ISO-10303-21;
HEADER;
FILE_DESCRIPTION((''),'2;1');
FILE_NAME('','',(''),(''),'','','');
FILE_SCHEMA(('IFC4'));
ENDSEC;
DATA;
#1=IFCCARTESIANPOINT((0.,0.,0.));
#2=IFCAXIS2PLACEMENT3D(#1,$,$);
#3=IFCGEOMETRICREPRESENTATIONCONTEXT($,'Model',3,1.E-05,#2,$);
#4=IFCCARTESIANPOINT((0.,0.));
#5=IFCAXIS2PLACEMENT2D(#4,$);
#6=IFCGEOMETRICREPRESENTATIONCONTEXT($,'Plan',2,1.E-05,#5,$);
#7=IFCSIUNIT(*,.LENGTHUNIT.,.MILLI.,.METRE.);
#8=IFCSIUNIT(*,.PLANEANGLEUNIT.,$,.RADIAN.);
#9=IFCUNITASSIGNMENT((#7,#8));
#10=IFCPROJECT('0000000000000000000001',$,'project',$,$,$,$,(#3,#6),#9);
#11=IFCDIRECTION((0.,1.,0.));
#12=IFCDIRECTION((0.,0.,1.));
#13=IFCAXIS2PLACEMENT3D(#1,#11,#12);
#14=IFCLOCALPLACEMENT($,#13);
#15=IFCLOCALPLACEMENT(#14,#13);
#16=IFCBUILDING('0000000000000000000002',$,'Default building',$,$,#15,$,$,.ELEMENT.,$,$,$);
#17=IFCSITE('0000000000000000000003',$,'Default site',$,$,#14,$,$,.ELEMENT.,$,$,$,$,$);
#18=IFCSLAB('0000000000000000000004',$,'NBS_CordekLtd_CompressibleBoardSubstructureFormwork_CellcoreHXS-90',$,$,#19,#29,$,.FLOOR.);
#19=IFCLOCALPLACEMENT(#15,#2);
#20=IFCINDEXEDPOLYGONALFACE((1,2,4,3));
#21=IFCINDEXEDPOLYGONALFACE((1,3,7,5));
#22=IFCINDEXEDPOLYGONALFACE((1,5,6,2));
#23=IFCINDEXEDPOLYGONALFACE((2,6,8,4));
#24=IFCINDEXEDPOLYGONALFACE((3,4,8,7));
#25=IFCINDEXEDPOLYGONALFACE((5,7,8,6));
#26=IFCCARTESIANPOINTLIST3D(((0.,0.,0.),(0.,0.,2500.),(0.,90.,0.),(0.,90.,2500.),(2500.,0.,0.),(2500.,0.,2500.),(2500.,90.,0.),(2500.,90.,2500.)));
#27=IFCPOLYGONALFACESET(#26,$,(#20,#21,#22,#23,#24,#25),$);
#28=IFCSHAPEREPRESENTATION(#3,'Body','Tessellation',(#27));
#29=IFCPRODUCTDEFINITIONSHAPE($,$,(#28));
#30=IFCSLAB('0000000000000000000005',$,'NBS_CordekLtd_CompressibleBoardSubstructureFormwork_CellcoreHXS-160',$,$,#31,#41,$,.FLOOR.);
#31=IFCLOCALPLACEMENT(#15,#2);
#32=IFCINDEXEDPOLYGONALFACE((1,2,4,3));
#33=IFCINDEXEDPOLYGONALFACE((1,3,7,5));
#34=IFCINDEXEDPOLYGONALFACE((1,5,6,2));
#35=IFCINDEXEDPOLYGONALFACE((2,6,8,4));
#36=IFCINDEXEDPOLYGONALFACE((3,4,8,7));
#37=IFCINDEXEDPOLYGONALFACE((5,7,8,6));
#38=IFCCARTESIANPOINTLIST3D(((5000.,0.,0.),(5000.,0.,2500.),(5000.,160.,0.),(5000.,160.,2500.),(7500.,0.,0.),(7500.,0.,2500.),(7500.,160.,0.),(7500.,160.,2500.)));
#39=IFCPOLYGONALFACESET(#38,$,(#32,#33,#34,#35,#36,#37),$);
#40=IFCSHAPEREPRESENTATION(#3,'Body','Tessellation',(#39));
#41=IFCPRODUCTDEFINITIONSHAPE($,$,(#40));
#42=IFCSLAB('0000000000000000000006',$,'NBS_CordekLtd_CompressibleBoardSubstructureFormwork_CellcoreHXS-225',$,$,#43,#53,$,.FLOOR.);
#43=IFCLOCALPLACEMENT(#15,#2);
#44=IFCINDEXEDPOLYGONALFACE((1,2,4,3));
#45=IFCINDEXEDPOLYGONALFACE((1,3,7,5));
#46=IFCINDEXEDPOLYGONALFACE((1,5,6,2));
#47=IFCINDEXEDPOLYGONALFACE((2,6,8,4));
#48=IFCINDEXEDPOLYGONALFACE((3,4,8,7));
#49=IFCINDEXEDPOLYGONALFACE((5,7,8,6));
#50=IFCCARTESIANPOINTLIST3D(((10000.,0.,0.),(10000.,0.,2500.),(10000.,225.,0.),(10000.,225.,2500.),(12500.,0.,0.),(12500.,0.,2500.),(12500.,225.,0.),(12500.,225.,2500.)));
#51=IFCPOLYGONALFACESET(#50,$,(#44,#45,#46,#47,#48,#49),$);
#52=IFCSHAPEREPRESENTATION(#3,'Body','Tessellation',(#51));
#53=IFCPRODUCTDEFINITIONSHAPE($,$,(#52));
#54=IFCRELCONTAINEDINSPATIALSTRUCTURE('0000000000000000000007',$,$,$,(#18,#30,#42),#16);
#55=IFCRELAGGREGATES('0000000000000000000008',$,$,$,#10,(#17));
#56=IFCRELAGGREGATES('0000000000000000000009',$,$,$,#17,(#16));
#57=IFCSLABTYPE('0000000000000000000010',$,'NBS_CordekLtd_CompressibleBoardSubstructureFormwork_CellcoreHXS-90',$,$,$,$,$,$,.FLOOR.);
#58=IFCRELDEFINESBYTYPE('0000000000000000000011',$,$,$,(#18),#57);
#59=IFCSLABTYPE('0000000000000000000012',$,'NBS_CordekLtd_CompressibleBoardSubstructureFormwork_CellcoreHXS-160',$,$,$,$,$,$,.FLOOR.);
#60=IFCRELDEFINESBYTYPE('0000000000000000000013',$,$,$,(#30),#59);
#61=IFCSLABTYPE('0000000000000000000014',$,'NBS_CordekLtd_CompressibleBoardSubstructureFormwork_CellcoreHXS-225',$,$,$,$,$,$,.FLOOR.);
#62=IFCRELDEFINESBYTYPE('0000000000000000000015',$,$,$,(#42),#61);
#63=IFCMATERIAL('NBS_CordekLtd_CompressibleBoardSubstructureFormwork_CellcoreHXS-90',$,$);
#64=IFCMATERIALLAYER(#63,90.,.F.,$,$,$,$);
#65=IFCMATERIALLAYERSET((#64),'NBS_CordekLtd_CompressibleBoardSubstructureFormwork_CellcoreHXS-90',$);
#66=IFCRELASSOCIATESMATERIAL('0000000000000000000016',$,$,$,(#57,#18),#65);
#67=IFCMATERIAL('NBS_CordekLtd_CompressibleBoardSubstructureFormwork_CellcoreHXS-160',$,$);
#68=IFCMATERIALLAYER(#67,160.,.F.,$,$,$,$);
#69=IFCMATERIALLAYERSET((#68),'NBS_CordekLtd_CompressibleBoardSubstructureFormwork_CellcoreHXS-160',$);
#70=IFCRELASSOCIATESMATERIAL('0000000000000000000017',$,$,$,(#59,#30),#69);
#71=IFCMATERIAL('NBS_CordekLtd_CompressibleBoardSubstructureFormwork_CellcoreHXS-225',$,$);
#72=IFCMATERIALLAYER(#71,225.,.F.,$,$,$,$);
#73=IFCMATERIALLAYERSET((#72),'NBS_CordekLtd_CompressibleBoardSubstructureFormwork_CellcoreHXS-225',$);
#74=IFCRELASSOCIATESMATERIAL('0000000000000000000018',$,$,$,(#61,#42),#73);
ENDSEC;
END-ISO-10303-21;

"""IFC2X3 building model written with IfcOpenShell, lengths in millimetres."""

from ifc_helpers import new_model, si_unit, frame, frame_2d, origin, origin_with_axes, origin_2d, place, context, project, spatial, rectangle, extrude, material, layer, layer_set, layer_usage, type_object, element, save


model = new_model("IFC2X3")

# Units and contexts
model_context = context("Model", 3, precision=1e-05, world=origin())
plan_context = context("Plan", 2, precision=1e-05, world=origin_2d())
ifc_project = project(units=[si_unit("LENGTHUNIT", "METRE", prefix="MILLI"), si_unit("PLANEANGLEUNIT", "RADIAN")], contexts=[model_context, plan_context])

# Site, building
site_placement = place(None, frame((0.0, 0.0, 0.0), z_axis=(0.0, 1.0, 0.0), x_axis=(0.0, 0.0, 1.0)))
site = spatial("IfcSite", under=ifc_project, at=site_placement, Name="Default site", CompositionType="ELEMENT")
building_placement = place(site_placement, frame((0.0, 0.0, 0.0), z_axis=(0.0, 1.0, 0.0), x_axis=(0.0, 0.0, 1.0)))
building = spatial("IfcBuilding", under=site, at=building_placement, Name="Default building", CompositionType="ELEMENT")

# Slabs
ifc_material_1 = material(Name="NBS_CordekLtd_CompressibleBoardSubstructureFormwork_CellcoreHXS-90")
ifc_layer_1 = layer(ifc_material_1, 90.0, ventilated=False)
ifc_layer_set_1 = layer_set([ifc_layer_1], Name="NBS_CordekLtd_CompressibleBoardSubstructureFormwork_CellcoreHXS-90")
ifc_layer_usage_1 = layer_usage(ifc_layer_set_1, "AXIS3", "NEGATIVE", 0.0)
slab_type_1 = type_object("IfcSlabType", Name="NBS_CordekLtd_CompressibleBoardSubstructureFormwork_CellcoreHXS-90", PredefinedType="FLOOR", material=ifc_layer_set_1)
slab_1_placement = place(None, origin())
element("IfcSlab", 1, at=slab_1_placement, inside=building, type_object=slab_type_1, material=ifc_layer_usage_1, Name="NBS_CordekLtd_CompressibleBoardSubstructureFormwork_CellcoreHXS-90", PredefinedType="FLOOR", context=model_context, shape_type="SweptSolid", body=[
    extrude(rectangle(XDim=2500.0, YDim=2500.0, at=frame_2d((1250.0, 1250.0))), origin_with_axes(), (0.0, 0.0, 1.0), 90.0),
])
ifc_material_2 = material(Name="NBS_CordekLtd_CompressibleBoardSubstructureFormwork_CellcoreHXS-160")
ifc_layer_2 = layer(ifc_material_2, 160.0, ventilated=False)
ifc_layer_set_2 = layer_set([ifc_layer_2], Name="NBS_CordekLtd_CompressibleBoardSubstructureFormwork_CellcoreHXS-160")
ifc_layer_usage_2 = layer_usage(ifc_layer_set_2, "AXIS3", "NEGATIVE", 0.0)
slab_type_2 = type_object("IfcSlabType", Name="NBS_CordekLtd_CompressibleBoardSubstructureFormwork_CellcoreHXS-160", PredefinedType="FLOOR", material=ifc_layer_set_2)
slab_2_placement = place(None, frame((0.0, 5000.0, 0.0)))
element("IfcSlab", 2, at=slab_2_placement, inside=building, type_object=slab_type_2, material=ifc_layer_usage_2, Name="NBS_CordekLtd_CompressibleBoardSubstructureFormwork_CellcoreHXS-160", PredefinedType="FLOOR", context=model_context, shape_type="SweptSolid", body=[
    extrude(rectangle(XDim=2500.0, YDim=2500.0, at=frame_2d((1250.0, 1250.0))), origin_with_axes(), (0.0, 0.0, 1.0), 160.0),
])
ifc_material_3 = material(Name="NBS_CordekLtd_CompressibleBoardSubstructureFormwork_CellcoreHXS-225")
ifc_layer_3 = layer(ifc_material_3, 225.0, ventilated=False)
ifc_layer_set_3 = layer_set([ifc_layer_3], Name="NBS_CordekLtd_CompressibleBoardSubstructureFormwork_CellcoreHXS-225")
ifc_layer_usage_3 = layer_usage(ifc_layer_set_3, "AXIS3", "NEGATIVE", 0.0)
slab_type_3 = type_object("IfcSlabType", Name="NBS_CordekLtd_CompressibleBoardSubstructureFormwork_CellcoreHXS-225", PredefinedType="FLOOR", material=ifc_layer_set_3)
slab_3_placement = place(None, frame((0.0, 10000.0, 0.0)))
element("IfcSlab", 3, at=slab_3_placement, inside=building, type_object=slab_type_3, material=ifc_layer_usage_3, Name="NBS_CordekLtd_CompressibleBoardSubstructureFormwork_CellcoreHXS-225", PredefinedType="FLOOR", context=model_context, shape_type="SweptSolid", body=[
    extrude(rectangle(XDim=2500.0, YDim=2500.0, at=frame_2d((1250.0, 1250.0))), origin_with_axes(), (0.0, 0.0, 1.0), 225.0),
])

save(model, "model.ifc")
